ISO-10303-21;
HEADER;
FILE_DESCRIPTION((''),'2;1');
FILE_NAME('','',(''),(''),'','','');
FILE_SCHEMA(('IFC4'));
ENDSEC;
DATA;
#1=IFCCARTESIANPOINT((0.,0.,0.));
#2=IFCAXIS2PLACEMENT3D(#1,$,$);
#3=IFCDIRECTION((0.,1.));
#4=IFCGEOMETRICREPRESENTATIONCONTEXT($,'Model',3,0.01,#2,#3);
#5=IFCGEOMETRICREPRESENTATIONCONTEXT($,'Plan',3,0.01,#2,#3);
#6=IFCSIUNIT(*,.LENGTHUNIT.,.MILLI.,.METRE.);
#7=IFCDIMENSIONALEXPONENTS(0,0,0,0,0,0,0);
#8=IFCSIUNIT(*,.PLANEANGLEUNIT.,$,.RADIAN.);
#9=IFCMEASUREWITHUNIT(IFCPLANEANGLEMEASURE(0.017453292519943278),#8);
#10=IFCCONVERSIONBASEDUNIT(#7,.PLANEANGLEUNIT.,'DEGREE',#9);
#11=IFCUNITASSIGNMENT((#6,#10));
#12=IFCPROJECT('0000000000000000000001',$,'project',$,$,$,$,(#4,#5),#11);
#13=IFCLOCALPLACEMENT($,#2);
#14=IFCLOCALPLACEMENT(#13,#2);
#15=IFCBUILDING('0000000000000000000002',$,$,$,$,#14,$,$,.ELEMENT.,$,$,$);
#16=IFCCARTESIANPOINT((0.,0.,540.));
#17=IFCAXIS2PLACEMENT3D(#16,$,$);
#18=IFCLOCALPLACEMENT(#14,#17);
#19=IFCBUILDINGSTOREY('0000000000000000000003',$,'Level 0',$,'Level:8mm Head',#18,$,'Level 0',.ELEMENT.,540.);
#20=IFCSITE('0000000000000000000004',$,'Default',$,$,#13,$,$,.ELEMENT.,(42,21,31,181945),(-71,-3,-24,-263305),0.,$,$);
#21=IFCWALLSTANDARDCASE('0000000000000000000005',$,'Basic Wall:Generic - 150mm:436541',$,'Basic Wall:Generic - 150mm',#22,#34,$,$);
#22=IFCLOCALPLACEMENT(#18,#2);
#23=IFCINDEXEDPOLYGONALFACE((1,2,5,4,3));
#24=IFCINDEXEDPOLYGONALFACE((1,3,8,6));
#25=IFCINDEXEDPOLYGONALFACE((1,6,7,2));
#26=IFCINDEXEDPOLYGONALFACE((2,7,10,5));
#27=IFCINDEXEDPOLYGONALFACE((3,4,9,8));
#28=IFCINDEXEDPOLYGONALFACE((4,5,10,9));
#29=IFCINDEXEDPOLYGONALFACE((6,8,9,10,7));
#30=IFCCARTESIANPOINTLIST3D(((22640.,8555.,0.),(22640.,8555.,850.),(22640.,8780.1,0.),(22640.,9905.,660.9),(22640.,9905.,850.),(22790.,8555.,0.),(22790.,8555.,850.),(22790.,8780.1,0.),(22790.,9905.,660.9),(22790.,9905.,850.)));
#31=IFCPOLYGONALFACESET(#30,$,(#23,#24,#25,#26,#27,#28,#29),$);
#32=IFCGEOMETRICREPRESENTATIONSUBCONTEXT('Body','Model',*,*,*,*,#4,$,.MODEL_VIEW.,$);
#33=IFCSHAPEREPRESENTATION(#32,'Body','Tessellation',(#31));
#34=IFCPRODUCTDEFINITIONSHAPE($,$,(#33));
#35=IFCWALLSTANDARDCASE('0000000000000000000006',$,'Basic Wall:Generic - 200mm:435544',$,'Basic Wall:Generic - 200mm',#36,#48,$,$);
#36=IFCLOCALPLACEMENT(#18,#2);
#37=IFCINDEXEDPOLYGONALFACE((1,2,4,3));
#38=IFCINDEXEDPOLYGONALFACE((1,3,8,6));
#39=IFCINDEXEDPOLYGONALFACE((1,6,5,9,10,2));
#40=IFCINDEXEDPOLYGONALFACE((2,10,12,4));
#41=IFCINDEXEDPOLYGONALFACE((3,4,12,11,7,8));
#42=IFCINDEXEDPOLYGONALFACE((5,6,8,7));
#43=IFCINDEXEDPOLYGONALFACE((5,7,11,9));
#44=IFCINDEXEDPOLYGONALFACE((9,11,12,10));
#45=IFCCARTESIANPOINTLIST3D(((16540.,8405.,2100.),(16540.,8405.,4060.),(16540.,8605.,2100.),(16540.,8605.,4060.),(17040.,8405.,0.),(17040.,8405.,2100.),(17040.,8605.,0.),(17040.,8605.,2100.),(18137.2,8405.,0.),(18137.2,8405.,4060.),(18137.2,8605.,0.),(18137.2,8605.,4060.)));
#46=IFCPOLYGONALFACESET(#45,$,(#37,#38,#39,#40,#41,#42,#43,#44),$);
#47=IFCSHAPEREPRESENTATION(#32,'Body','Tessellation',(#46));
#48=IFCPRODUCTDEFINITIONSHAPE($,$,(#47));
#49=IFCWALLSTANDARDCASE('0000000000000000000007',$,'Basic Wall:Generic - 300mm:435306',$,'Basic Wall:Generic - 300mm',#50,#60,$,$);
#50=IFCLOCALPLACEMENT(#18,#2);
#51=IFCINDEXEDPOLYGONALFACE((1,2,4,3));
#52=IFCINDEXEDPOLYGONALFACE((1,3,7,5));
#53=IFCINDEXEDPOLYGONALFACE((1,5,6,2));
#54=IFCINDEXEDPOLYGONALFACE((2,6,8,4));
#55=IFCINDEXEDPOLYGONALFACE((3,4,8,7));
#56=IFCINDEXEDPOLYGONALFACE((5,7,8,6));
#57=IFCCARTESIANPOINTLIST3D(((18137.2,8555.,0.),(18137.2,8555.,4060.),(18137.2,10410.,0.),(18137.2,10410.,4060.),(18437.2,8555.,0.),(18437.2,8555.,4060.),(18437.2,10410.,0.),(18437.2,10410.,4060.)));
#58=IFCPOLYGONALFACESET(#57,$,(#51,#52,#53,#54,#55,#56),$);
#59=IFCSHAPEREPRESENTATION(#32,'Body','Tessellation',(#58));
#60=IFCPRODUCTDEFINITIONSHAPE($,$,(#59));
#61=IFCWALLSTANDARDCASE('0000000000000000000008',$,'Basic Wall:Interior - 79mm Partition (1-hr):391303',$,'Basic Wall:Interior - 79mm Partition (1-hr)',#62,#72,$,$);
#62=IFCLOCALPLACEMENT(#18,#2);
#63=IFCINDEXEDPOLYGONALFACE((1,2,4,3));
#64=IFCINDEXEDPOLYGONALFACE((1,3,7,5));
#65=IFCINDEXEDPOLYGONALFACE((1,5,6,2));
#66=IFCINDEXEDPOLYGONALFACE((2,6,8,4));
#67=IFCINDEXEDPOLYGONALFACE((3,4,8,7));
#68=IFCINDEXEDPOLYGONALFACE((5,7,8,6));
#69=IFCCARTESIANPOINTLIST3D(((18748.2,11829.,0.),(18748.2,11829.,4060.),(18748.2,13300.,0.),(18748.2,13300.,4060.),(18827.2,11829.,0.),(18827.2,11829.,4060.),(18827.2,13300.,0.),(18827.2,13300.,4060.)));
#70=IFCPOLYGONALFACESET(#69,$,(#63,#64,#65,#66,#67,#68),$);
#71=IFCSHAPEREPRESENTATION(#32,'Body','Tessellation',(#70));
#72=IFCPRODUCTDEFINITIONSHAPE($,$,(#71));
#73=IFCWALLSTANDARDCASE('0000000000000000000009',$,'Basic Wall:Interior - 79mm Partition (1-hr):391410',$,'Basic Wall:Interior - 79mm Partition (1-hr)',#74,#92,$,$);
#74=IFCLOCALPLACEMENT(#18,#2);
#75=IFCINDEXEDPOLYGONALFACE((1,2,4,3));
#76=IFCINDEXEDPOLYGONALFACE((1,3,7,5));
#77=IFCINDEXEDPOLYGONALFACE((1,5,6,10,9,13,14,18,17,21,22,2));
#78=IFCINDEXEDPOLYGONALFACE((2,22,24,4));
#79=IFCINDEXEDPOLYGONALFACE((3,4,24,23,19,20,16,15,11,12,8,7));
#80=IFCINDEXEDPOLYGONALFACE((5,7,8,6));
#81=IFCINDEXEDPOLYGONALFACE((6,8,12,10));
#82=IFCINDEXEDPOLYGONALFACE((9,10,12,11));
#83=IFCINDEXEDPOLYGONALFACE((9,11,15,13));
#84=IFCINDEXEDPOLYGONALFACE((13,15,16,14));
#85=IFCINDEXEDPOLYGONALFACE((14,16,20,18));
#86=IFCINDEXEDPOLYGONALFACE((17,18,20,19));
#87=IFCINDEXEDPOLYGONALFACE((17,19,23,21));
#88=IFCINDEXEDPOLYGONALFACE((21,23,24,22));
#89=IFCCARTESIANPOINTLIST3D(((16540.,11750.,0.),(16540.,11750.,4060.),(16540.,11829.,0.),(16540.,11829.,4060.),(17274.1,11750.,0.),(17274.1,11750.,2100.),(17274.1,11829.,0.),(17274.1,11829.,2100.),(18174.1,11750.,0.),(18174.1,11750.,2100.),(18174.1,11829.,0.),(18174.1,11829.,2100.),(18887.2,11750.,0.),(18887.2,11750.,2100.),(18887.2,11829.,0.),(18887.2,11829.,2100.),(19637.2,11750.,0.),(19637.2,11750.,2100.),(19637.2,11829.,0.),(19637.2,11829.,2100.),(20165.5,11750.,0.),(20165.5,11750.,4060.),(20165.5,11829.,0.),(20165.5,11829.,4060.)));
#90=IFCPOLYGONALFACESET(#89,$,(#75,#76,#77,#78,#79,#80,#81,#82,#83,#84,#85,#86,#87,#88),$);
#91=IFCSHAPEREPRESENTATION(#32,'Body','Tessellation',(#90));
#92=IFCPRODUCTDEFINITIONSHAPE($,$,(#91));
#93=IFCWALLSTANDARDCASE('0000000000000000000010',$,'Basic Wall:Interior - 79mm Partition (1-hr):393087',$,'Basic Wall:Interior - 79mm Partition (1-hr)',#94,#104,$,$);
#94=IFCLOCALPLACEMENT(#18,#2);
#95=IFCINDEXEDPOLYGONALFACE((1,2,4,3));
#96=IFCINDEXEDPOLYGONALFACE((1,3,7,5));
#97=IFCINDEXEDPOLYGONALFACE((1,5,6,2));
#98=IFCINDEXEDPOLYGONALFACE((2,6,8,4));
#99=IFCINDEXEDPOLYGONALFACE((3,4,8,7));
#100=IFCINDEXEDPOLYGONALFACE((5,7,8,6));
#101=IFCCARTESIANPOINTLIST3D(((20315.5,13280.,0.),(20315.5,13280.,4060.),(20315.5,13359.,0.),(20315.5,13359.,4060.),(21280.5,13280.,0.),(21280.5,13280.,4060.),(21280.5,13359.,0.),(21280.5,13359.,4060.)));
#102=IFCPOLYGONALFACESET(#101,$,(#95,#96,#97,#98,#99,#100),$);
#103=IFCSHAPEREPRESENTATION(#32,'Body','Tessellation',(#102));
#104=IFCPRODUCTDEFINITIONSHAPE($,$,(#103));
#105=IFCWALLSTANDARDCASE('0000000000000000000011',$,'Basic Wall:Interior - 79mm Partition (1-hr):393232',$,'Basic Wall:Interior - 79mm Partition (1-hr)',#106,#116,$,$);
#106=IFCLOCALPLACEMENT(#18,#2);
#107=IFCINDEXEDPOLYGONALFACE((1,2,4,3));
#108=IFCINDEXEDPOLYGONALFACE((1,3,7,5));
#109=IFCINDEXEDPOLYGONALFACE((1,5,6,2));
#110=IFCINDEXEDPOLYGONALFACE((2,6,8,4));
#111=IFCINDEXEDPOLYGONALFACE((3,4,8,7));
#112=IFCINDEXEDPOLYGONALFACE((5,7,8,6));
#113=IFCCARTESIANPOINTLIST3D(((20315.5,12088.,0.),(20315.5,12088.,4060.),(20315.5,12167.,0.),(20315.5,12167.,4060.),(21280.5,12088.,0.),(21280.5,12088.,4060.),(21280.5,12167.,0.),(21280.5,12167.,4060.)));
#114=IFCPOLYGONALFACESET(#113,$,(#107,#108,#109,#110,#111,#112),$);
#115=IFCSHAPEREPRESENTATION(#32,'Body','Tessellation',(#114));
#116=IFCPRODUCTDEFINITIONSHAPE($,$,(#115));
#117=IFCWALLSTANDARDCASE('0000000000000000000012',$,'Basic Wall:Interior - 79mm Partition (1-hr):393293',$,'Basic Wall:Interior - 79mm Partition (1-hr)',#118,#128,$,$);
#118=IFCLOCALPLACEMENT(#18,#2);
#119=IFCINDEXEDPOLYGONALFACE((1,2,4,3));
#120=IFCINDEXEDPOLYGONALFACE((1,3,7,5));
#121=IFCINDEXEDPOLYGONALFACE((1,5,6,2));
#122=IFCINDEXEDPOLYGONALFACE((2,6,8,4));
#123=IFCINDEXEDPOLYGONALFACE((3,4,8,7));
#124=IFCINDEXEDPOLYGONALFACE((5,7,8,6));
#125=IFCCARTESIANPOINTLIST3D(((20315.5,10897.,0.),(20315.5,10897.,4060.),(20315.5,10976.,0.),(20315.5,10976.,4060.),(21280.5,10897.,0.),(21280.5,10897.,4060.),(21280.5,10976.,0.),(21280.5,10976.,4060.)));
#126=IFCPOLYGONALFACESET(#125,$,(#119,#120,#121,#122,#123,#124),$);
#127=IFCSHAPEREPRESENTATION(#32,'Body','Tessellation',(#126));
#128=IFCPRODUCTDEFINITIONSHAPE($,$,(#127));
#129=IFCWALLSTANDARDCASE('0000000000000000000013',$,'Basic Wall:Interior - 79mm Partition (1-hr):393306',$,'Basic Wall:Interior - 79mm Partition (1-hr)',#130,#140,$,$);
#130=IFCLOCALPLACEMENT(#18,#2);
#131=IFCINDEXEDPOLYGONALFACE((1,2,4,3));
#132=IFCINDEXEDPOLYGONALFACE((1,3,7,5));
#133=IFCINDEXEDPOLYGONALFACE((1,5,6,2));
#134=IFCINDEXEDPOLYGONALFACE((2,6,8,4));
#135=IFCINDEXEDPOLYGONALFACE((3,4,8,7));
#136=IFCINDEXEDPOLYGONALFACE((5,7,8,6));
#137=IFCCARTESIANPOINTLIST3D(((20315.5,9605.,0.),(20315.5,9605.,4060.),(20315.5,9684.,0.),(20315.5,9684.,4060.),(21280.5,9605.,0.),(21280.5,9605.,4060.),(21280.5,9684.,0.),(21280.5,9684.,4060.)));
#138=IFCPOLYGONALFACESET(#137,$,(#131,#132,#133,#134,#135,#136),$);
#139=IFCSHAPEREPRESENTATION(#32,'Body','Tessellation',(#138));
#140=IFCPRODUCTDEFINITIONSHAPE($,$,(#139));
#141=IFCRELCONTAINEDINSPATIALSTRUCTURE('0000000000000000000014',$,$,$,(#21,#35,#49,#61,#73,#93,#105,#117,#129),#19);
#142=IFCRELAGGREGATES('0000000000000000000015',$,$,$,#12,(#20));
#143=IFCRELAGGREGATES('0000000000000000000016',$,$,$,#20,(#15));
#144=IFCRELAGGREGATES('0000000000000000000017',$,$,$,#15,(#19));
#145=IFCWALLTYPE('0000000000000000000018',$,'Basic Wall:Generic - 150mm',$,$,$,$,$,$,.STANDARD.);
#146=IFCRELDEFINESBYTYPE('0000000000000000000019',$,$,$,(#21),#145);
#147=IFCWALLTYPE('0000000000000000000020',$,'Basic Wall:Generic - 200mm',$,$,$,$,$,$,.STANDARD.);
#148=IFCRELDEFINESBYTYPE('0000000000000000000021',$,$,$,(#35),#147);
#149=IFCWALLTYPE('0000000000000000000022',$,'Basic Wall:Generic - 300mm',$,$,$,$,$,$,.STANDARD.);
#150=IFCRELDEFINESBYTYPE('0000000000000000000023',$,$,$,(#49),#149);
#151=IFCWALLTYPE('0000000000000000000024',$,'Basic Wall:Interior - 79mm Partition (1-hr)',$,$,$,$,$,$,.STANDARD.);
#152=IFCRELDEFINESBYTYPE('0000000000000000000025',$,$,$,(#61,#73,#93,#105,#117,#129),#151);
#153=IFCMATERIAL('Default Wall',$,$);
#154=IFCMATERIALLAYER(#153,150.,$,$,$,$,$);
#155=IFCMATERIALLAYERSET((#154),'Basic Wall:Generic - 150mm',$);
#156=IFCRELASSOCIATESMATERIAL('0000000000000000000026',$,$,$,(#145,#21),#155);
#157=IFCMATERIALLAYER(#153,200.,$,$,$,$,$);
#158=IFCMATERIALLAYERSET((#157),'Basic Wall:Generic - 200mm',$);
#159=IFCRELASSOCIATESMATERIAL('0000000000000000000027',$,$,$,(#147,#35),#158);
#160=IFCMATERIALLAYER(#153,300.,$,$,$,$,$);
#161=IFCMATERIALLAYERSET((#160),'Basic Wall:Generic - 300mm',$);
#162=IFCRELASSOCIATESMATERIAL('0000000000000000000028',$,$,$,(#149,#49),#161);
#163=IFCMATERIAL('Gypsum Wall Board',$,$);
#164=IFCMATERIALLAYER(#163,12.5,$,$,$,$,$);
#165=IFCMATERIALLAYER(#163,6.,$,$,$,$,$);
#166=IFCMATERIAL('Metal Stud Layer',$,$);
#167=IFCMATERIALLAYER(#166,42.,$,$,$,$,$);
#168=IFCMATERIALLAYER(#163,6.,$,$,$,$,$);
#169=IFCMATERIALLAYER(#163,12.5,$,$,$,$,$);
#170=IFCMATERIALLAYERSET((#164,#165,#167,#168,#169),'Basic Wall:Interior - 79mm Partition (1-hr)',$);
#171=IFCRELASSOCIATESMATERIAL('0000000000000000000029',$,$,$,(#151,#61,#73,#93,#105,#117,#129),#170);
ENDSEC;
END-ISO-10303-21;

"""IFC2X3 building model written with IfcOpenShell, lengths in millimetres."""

from ifc_helpers import new_model, entity, si_unit, converted_unit, direction, frame, frame_2d, origin, place, context, subcontext, project, spatial, polyline, rectangle, extrude, clip, halfspace, bounded_halfspace, material, layer, layer_set, layer_usage, type_object, element, save


model = new_model("IFC2X3")

# Units and contexts
model_context = context("Model", 3, precision=0.01, world=origin(), true_north=direction((0.0, 1.0)))
plan_context = context("Plan", 3, precision=0.01, world=origin(), true_north=direction((0.0, 1.0)))
body_context = subcontext(model_context, "Body", "Model", "MODEL_VIEW")
ifc_project = project(units=[si_unit("LENGTHUNIT", "METRE", prefix="MILLI"), converted_unit("PLANEANGLEUNIT", "DEGREE", entity("IfcPlaneAngleMeasure", 0.017453292519943278), si_unit("PLANEANGLEUNIT", "RADIAN"), dimensions=[0, 0, 0, 0, 0, 0, 0])], contexts=[model_context, plan_context])

# Site, building, storey
site_placement = place(None, origin())
site = spatial("IfcSite", under=ifc_project, at=site_placement, Name="Default", CompositionType="ELEMENT", RefLatitude=(42, 21, 31, 181945), RefLongitude=(-71, -3, -24, -263305), RefElevation=0.0)
building_placement = place(site_placement, origin())
building = spatial("IfcBuilding", under=site, at=building_placement, CompositionType="ELEMENT")
storey_placement = place(building_placement, frame((0.0, 0.0, 540.0)))
storey = spatial("IfcBuildingStorey", under=building, at=storey_placement, Name="Level 0", ObjectType="Level:8mm Head", LongName="Level 0", CompositionType="ELEMENT", Elevation=540.0)

# Shared definitions
ifc_material_1 = material(Name="Default Wall")
ifc_layer_1 = layer(ifc_material_1, 150.0)
ifc_layer_set_1 = layer_set([ifc_layer_1], Name="Basic Wall:Generic - 150mm")
wall_type_1 = type_object("IfcWallType", Name="Basic Wall:Generic - 150mm", PredefinedType="STANDARD", material=ifc_layer_set_1)

# Wall
ifc_layer_usage_1 = layer_usage(ifc_layer_set_1, "AXIS2", "POSITIVE", -75.0)
wall_1_placement = place(storey_placement, frame((22715.0, 9905.0, 0.0), z_axis=(0.0, 0.0, 1.0), x_axis=(0.0, -1.0, 0.0)))
element("IfcWallStandardCase", 1, at=wall_1_placement, inside=storey, type_object=wall_type_1, material=ifc_layer_usage_1, Name="Basic Wall:Generic - 150mm:436541", ObjectType="Basic Wall:Generic - 150mm", context=body_context, shape_type="Clipping", body=[
    clip(extrude(rectangle(XDim=1350.0, YDim=150.0, at=frame_2d((675.0, 0.0), x_axis=(-1.0, 0.0))), origin(), (0.0, 0.0, 1.0), 850.0), halfspace(frame((1124.9, -75.0, 0.0), z_axis=(-0.506549, 0.0, -0.862211), x_axis=(0.0, 1.0, 0.0)), False)),
])

# Wall, opening
ifc_layer_2 = layer(ifc_material_1, 200.0)
ifc_layer_set_2 = layer_set([ifc_layer_2], Name="Basic Wall:Generic - 200mm")
ifc_layer_usage_2 = layer_usage(ifc_layer_set_2, "AXIS2", "NEGATIVE", 100.0)
wall_type_2 = type_object("IfcWallType", Name="Basic Wall:Generic - 200mm", PredefinedType="STANDARD", material=ifc_layer_set_2)
wall_2_placement = place(storey_placement, frame((18137.2, 8505.0, 0.0), z_axis=(0.0, 0.0, 1.0), x_axis=(-1.0, 0.0, 0.0)))
wall_2 = element("IfcWallStandardCase", 2, at=wall_2_placement, inside=storey, type_object=wall_type_2, material=ifc_layer_usage_2, Name="Basic Wall:Generic - 200mm:435544", ObjectType="Basic Wall:Generic - 200mm", context=body_context, shape_type="Clipping", body=[
    clip(extrude(rectangle(XDim=1597.2, YDim=200.0, at=frame_2d((798.6, 0.0), x_axis=(-1.0, 0.0))), origin(), (0.0, 0.0, 1.0), 4060.0), bounded_halfspace(frame((1597.2, -100.0, 4060.0), z_axis=(0.0, 0.0, -1.0), x_axis=(0.0, 1.0, 0.0)), True, frame((1597.2, -100.0, 4060.0)), polyline([(0.0, 0.0), (0.0, 200.0), (-1597.2, 200.0), (-1597.2, 50.0), (-1597.2, 0.0), (0.0, 0.0)]))),
])
opening_1_placement = place(wall_2_placement, frame((1097.2, -100.0, 0.0)))
element("IfcOpeningElement", 3, at=opening_1_placement, cuts=wall_2, ObjectType="Opening", context=body_context, shape_type="SweptSolid", body=[
    extrude(rectangle(XDim=2100.0, YDim=900.0, at=frame_2d((1050.0, 450.0), x_axis=(1.0, 0.0))), frame((0.0, 0.0, 0.0), z_axis=(0.0, 1.0, 0.0), x_axis=(0.0, 0.0, 1.0)), (0.0, 0.0, 1.0), 200.0),
])

# Walls
ifc_layer_3 = layer(ifc_material_1, 300.0)
ifc_layer_set_3 = layer_set([ifc_layer_3], Name="Basic Wall:Generic - 300mm")
ifc_layer_usage_3 = layer_usage(ifc_layer_set_3, "AXIS2", "NEGATIVE", 150.0)
wall_type_3 = type_object("IfcWallType", Name="Basic Wall:Generic - 300mm", PredefinedType="STANDARD", material=ifc_layer_set_3)
wall_3_placement = place(storey_placement, frame((18287.2, 10410.0, 0.0), z_axis=(0.0, 0.0, 1.0), x_axis=(0.0, -1.0, 0.0)))
element("IfcWallStandardCase", 4, at=wall_3_placement, inside=storey, type_object=wall_type_3, material=ifc_layer_usage_3, Name="Basic Wall:Generic - 300mm:435306", ObjectType="Basic Wall:Generic - 300mm", context=body_context, shape_type="Clipping", body=[
    clip(extrude(rectangle(XDim=1855.0, YDim=300.0, at=frame_2d((927.5, 0.0), x_axis=(-1.0, 0.0))), origin(), (0.0, 0.0, 1.0), 4060.0), bounded_halfspace(frame((0.0, -150.0, 4060.0), z_axis=(0.0, 0.0, -1.0), x_axis=(1.0, 0.0, 0.0)), True, frame((0.0, -150.0, 4060.0)), polyline([(0.0, 0.0), (1805.0, 0.0), (1855.0, 0.0), (1855.0, 300.0), (0.0, 300.0), (0.0, 0.0)]))),
])
ifc_material_2 = material(Name="Gypsum Wall Board")
ifc_layer_4 = layer(ifc_material_2, 12.5)
ifc_layer_5 = layer(ifc_material_2, 6.0)
ifc_material_3 = material(Name="Metal Stud Layer")
ifc_layer_6 = layer(ifc_material_3, 42.0)
ifc_layer_7 = layer(ifc_material_2, 6.0)
ifc_layer_8 = layer(ifc_material_2, 12.5)
ifc_layer_set_4 = layer_set([ifc_layer_4, ifc_layer_5, ifc_layer_6, ifc_layer_7, ifc_layer_8], Name="Basic Wall:Interior - 79mm Partition (1-hr)")
ifc_layer_usage_4 = layer_usage(ifc_layer_set_4, "AXIS2", "NEGATIVE", 39.5)
wall_type_4 = type_object("IfcWallType", Name="Basic Wall:Interior - 79mm Partition (1-hr)", PredefinedType="STANDARD", material=ifc_layer_set_4)
wall_4_placement = place(storey_placement, frame((18787.7, 13300.0, 0.0), z_axis=(0.0, 0.0, 1.0), x_axis=(0.0, -1.0, 0.0)))
element("IfcWallStandardCase", 5, at=wall_4_placement, inside=storey, type_object=wall_type_4, material=ifc_layer_usage_4, Name="Basic Wall:Interior - 79mm Partition (1-hr):391303", ObjectType="Basic Wall:Interior - 79mm Partition (1-hr)", context=body_context, shape_type="Clipping", body=[
    clip(extrude(rectangle(XDim=1471.0, YDim=79.0, at=frame_2d((735.5, 0.0), x_axis=(-1.0, 0.0))), origin(), (0.0, 0.0, 1.0), 4060.0), bounded_halfspace(frame((0.0, -39.5, 4060.0), z_axis=(0.0, 0.0, -1.0), x_axis=(1.0, 0.0, 0.0)), True, frame((0.0, -39.5, 4060.0)), polyline([(0.0, 0.0), (1471.0, 0.0), (1471.0, 79.0), (0.0, 79.0), (0.0, 0.0)]))),
])

# Wall, openings
wall_5_placement = place(storey_placement, frame((20165.5, 11789.5, 0.0), z_axis=(0.0, 0.0, 1.0), x_axis=(-1.0, 0.0, 0.0)))
wall_5 = element("IfcWallStandardCase", 6, at=wall_5_placement, inside=storey, type_object=wall_type_4, material=ifc_layer_usage_4, Name="Basic Wall:Interior - 79mm Partition (1-hr):391410", ObjectType="Basic Wall:Interior - 79mm Partition (1-hr)", context=body_context, shape_type="Clipping", body=[
    clip(extrude(rectangle(XDim=3625.5, YDim=79.0, at=frame_2d((1812.8, 0.0), x_axis=(-1.0, 0.0))), origin(), (0.0, 0.0, 1.0), 4060.0), bounded_halfspace(frame((0.0, -39.5, 4060.0), z_axis=(0.0, 0.0, -1.0), x_axis=(0.0, 1.0, 0.0)), True, frame((0.0, -39.5, 4060.0)), polyline([(0.0, 0.0), (1338.3, 0.0), (1417.3, 0.0), (3625.5, 0.0), (3625.5, 79.0), (0.0, 79.0), (0.0, 0.0)]))),
])
opening_2_placement = place(wall_5_placement, frame((1278.3, 39.5, 0.0)))
element("IfcOpeningElement", 7, at=opening_2_placement, cuts=wall_5, ObjectType="Opening", context=body_context, shape_type="SweptSolid", body=[
    extrude(rectangle(XDim=2100.0, YDim=750.0, at=frame_2d((1050.0, 375.0), x_axis=(1.0, 0.0))), frame((0.0, 0.0, 0.0), z_axis=(0.0, -1.0, 0.0), x_axis=(0.0, 0.0, 1.0)), (0.0, 0.0, 1.0), 79.0),
])
opening_3_placement = place(wall_5_placement, frame((1991.4, -39.5, 0.0)))
element("IfcOpeningElement", 8, at=opening_3_placement, cuts=wall_5, ObjectType="Opening", context=body_context, shape_type="SweptSolid", body=[
    extrude(rectangle(XDim=2100.0, YDim=900.0, at=frame_2d((1050.0, 450.0), x_axis=(1.0, 0.0))), frame((0.0, 0.0, 0.0), z_axis=(0.0, 1.0, 0.0), x_axis=(0.0, 0.0, 1.0)), (0.0, 0.0, 1.0), 79.0),
])

# Walls
for number, where, name in (
    (9, (20315.5, 13319.5, 0.0), "Basic Wall:Interior - 79mm Partition (1-hr):393087"),
    (10, (20315.5, 12127.5, 0.0), "Basic Wall:Interior - 79mm Partition (1-hr):393232"),
    (11, (20315.5, 10936.5, 0.0), "Basic Wall:Interior - 79mm Partition (1-hr):393293"),
):
    element("IfcWallStandardCase", number, at=place(storey_placement, frame(where)), inside=storey, type_object=wall_type_4, material=ifc_layer_usage_4, Name=name, ObjectType="Basic Wall:Interior - 79mm Partition (1-hr)", context=body_context, shape_type="Clipping", body=[
        clip(extrude(rectangle(XDim=965.0, YDim=79.0, at=frame_2d((482.5, 0.0), x_axis=(-1.0, 0.0))), origin(), (0.0, 0.0, 1.0), 4060.0), bounded_halfspace(frame((0.0, -39.5, 4060.0), z_axis=(0.0, 0.0, -1.0), x_axis=(0.0, -1.0, 0.0)), True, frame((0.0, -39.5, 4060.0)), polyline([(0.0, 0.0), (965.0, 0.0), (965.0, 79.0), (0.0, 79.0), (0.0, 0.0)]))),
    ])
ifc_layer_usage_5 = layer_usage(ifc_layer_set_4, "AXIS2", "POSITIVE", -39.5)
wall_6_placement = place(storey_placement, frame((20315.5, 9644.5, 0.0)))
element("IfcWallStandardCase", 12, at=wall_6_placement, inside=storey, type_object=wall_type_4, material=ifc_layer_usage_5, Name="Basic Wall:Interior - 79mm Partition (1-hr):393306", ObjectType="Basic Wall:Interior - 79mm Partition (1-hr)", context=body_context, shape_type="Clipping", body=[
    clip(extrude(rectangle(XDim=965.0, YDim=79.0, at=frame_2d((482.5, 0.0), x_axis=(-1.0, 0.0))), origin(), (0.0, 0.0, 1.0), 4060.0), bounded_halfspace(frame((0.0, -39.5, 4060.0), z_axis=(0.0, 0.0, -1.0), x_axis=(0.0, -1.0, 0.0)), True, frame((0.0, -39.5, 4060.0)), polyline([(0.0, 0.0), (965.0, 0.0), (965.0, 79.0), (0.0, 79.0), (0.0, 0.0)]))),
])

save(model, "model.ifc")
